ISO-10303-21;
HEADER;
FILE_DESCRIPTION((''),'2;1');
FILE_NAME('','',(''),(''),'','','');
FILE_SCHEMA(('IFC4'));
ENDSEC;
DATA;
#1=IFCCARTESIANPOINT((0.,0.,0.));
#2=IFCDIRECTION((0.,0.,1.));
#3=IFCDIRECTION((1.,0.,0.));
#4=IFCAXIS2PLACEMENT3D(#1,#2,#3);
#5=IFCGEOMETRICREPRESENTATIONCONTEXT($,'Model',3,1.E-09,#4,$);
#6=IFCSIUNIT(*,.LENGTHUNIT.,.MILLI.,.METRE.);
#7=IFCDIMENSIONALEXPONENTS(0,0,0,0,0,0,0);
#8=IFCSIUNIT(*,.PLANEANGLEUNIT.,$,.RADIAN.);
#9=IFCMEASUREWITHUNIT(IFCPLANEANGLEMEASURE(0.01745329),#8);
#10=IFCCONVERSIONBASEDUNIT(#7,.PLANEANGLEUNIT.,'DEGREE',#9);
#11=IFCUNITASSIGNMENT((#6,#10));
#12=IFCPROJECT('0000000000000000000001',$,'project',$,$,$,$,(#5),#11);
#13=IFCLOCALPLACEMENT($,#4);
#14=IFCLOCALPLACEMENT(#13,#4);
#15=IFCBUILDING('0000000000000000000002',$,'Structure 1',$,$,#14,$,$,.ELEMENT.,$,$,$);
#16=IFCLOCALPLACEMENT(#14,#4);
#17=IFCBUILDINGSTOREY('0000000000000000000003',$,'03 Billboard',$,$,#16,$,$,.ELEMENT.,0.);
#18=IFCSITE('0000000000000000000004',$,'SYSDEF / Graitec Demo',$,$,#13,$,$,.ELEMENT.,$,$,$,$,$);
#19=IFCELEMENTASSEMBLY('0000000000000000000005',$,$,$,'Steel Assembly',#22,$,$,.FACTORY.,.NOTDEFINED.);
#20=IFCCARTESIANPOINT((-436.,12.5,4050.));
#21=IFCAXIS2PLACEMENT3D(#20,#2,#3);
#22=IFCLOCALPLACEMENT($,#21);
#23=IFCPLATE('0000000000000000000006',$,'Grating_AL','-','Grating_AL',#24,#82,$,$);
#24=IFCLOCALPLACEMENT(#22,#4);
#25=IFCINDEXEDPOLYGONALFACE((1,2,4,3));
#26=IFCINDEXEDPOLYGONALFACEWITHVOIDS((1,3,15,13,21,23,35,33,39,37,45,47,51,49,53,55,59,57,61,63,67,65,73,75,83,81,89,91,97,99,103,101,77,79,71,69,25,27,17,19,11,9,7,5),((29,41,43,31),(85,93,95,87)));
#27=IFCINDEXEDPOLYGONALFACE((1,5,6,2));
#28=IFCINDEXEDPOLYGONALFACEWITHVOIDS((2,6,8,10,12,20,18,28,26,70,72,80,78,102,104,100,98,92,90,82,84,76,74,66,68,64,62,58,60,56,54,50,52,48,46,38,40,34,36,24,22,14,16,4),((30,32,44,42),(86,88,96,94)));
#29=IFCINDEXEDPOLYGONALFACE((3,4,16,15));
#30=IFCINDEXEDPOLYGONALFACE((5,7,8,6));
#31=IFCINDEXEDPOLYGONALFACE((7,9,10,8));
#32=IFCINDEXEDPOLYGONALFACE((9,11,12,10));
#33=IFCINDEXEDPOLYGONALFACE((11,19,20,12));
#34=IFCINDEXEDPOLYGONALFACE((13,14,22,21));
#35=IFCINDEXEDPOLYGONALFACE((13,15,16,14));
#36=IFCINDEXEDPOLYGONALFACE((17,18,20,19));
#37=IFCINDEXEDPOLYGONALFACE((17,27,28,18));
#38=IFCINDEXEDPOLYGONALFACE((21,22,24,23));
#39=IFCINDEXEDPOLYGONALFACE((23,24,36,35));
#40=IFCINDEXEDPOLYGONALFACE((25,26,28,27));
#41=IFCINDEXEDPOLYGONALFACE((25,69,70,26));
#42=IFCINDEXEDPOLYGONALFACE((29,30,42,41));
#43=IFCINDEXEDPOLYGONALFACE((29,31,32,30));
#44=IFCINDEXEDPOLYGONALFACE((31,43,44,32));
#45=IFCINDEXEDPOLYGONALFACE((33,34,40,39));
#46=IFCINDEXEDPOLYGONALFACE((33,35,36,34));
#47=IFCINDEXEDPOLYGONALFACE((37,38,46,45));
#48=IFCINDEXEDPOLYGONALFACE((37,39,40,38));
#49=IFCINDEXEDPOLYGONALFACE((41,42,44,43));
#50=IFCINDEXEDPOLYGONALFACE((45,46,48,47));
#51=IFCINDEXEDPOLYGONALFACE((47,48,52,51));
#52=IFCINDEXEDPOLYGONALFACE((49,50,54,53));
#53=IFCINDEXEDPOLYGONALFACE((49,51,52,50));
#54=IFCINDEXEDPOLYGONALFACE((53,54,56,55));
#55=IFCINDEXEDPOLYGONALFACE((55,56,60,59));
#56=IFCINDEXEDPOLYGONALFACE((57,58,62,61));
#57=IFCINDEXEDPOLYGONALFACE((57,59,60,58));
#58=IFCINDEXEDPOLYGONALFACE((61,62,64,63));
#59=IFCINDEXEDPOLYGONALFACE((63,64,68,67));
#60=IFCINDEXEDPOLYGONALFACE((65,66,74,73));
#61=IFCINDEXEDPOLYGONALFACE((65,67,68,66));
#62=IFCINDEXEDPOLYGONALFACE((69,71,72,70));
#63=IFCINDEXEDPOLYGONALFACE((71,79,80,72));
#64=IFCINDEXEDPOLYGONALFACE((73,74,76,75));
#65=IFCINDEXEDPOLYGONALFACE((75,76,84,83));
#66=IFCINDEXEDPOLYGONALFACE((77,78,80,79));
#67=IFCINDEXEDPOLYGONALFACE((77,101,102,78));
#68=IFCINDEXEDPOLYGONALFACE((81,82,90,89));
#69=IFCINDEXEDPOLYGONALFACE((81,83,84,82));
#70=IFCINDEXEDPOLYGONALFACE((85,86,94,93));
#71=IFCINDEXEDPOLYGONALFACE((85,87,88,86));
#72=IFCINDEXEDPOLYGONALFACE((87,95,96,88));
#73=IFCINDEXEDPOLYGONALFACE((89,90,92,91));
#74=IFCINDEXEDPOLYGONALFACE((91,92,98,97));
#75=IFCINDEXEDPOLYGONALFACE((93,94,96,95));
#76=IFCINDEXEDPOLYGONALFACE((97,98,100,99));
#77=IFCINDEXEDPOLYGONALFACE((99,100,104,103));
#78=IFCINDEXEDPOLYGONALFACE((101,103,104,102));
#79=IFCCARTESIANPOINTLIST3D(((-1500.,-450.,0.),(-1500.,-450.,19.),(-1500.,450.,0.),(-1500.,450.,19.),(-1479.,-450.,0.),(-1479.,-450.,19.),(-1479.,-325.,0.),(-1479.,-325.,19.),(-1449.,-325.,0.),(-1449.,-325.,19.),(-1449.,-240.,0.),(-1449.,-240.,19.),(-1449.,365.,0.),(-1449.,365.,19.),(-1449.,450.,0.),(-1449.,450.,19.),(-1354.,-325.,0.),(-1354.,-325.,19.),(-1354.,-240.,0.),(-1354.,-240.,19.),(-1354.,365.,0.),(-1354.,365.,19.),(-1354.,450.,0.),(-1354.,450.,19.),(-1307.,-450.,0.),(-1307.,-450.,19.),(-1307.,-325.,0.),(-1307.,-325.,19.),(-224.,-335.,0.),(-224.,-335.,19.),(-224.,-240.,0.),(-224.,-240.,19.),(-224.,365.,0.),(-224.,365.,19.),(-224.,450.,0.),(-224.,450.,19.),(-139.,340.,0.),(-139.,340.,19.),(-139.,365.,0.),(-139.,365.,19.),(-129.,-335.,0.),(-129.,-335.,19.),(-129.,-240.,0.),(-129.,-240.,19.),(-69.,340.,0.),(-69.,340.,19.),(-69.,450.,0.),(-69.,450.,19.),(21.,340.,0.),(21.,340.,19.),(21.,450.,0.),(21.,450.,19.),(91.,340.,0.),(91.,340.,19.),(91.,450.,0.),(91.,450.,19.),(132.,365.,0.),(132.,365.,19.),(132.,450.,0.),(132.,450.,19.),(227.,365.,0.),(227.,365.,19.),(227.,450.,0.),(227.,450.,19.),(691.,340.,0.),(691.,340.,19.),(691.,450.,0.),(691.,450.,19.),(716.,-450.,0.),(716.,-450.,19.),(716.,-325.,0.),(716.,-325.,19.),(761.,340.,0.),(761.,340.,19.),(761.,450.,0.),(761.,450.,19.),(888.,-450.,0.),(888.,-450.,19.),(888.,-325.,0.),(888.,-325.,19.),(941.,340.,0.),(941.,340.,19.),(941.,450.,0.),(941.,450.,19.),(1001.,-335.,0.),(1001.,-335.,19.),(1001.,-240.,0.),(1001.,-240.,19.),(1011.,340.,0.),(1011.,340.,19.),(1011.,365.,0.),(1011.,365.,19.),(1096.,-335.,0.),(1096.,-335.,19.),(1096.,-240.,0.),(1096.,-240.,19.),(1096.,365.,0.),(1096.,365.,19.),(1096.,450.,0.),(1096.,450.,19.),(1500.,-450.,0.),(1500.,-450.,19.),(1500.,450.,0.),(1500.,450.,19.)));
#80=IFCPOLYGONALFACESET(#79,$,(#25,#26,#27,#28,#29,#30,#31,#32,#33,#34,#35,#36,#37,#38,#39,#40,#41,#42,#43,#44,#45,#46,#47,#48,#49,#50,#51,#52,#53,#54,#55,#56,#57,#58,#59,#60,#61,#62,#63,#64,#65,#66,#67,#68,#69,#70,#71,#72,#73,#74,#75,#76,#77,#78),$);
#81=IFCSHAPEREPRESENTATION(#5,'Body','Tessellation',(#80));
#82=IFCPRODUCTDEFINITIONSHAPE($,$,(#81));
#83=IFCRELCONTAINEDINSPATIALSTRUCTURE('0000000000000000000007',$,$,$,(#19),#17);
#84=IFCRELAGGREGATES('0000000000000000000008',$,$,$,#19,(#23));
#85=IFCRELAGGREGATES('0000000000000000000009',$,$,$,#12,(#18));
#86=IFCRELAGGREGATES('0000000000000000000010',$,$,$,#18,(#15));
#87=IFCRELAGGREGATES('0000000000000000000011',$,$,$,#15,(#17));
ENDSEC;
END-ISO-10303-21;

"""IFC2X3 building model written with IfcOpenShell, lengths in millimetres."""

from ifc_helpers import new_model, entity, si_unit, converted_unit, frame, origin, origin_with_axes, place, context, project, spatial, polyline, outline, extrude, element, aggregate, save


model = new_model("IFC2X3")

# Units and contexts
model_context = context("Model", 3, precision=1e-09, world=origin_with_axes())
ifc_project = project(units=[si_unit("LENGTHUNIT", "METRE", prefix="MILLI"), converted_unit("PLANEANGLEUNIT", "DEGREE", entity("IfcPlaneAngleMeasure", 0.01745329), si_unit("PLANEANGLEUNIT", "RADIAN"), dimensions=[0, 0, 0, 0, 0, 0, 0])], contexts=[model_context])

# Site, building, storey
site_placement = place(None, origin_with_axes())
site = spatial("IfcSite", under=ifc_project, at=site_placement, Name="SYSDEF / Graitec Demo", CompositionType="ELEMENT")
building_placement = place(site_placement, origin_with_axes())
building = spatial("IfcBuilding", under=site, at=building_placement, Name="Structure 1", CompositionType="ELEMENT")
storey_placement = place(building_placement, origin_with_axes())
storey = spatial("IfcBuildingStorey", under=building, at=storey_placement, Name="03 Billboard", CompositionType="ELEMENT", Elevation=0.0)

# Element assembly, plate, openings
assembly_1_placement = place(None, frame((-436.0, 12.5, 4050.0), z_axis=(0.0, 0.0, 1.0), x_axis=(1.0, 0.0, 0.0)))
assembly_1 = element("IfcElementAssembly", 1, at=assembly_1_placement, inside=storey, ObjectType="Steel Assembly", AssemblyPlace="FACTORY", PredefinedType="NOTDEFINED")
plate_placement = place(assembly_1_placement, origin_with_axes())
plate = element("IfcPlate", 2, at=plate_placement, Name="Grating_AL", Description="-", ObjectType="Grating_AL", context=model_context, shape_type="SweptSolid", body=[
    extrude(outline(polyline([(-1500.0, -450.0), (1500.0, -450.0), (1500.0, 450.0), (-1500.0, 450.0), (-1500.0, -450.0)])), origin_with_axes(), (0.0, 0.0, 1.0), 19.0),
])
opening_1_placement = place(plate_placement, frame((0.0, 0.0, -0.1), z_axis=(0.0, 0.0, 1.0), x_axis=(1.0, 0.0, 0.0)))
element("IfcOpeningElement", 3, at=opening_1_placement, cuts=plate, ObjectType="Opening", context=model_context, shape_type="SweptSolid", body=[
    extrude(outline(polyline([(-1449.0, 365.0), (-1354.0, 365.0), (-1354.0, 460.0), (-1449.0, 460.0), (-1449.0, 365.0)])), origin(), (0.0, 0.0, 1.0), 19.2),
])
opening_2_placement = place(plate_placement, frame((0.0, 0.0, -0.1), z_axis=(0.0, 0.0, 1.0), x_axis=(1.0, 0.0, 0.0)))
element("IfcOpeningElement", 4, at=opening_2_placement, cuts=plate, ObjectType="Opening", context=model_context, shape_type="SweptSolid", body=[
    extrude(outline(polyline([(-224.0, 365.0), (-129.0, 365.0), (-129.0, 460.0), (-224.0, 460.0), (-224.0, 365.0)])), origin(), (0.0, 0.0, 1.0), 19.2),
])
opening_3_placement = place(plate_placement, frame((0.0, 0.0, -0.1), z_axis=(0.0, 0.0, 1.0), x_axis=(1.0, 0.0, 0.0)))
element("IfcOpeningElement", 5, at=opening_3_placement, cuts=plate, ObjectType="Opening", context=model_context, shape_type="SweptSolid", body=[
    extrude(outline(polyline([(-224.0, -335.0), (-129.0, -335.0), (-129.0, -240.0), (-224.0, -240.0), (-224.0, -335.0)])), origin(), (0.0, 0.0, 1.0), 19.2),
])
opening_4_placement = place(plate_placement, frame((0.0, 0.0, -0.1), z_axis=(0.0, 0.0, 1.0), x_axis=(1.0, 0.0, 0.0)))
element("IfcOpeningElement", 6, at=opening_4_placement, cuts=plate, ObjectType="Opening", context=model_context, shape_type="SweptSolid", body=[
    extrude(outline(polyline([(-1449.0, -335.0), (-1354.0, -335.0), (-1354.0, -240.0), (-1449.0, -240.0), (-1449.0, -335.0)])), origin(), (0.0, 0.0, 1.0), 19.2),
])
opening_5_placement = place(plate_placement, frame((0.0, 0.0, -0.1), z_axis=(0.0, 0.0, 1.0), x_axis=(1.0, 0.0, 0.0)))
element("IfcOpeningElement", 7, at=opening_5_placement, cuts=plate, ObjectType="Opening", context=model_context, shape_type="SweptSolid", body=[
    extrude(outline(polyline([(1001.0, 365.0), (1096.0, 365.0), (1096.0, 460.0), (1001.0, 460.0), (1001.0, 365.0)])), origin(), (0.0, 0.0, 1.0), 19.2),
])
opening_6_placement = place(plate_placement, frame((0.0, 0.0, -0.1), z_axis=(0.0, 0.0, 1.0), x_axis=(1.0, 0.0, 0.0)))
element("IfcOpeningElement", 8, at=opening_6_placement, cuts=plate, ObjectType="Opening", context=model_context, shape_type="SweptSolid", body=[
    extrude(outline(polyline([(1001.0, -335.0), (1096.0, -335.0), (1096.0, -240.0), (1001.0, -240.0), (1001.0, -335.0)])), origin(), (0.0, 0.0, 1.0), 19.2),
])
opening_7_placement = place(plate_placement, frame((0.0, 0.0, -0.1), z_axis=(0.0, 0.0, 1.0), x_axis=(1.0, 0.0, 0.0)))
element("IfcOpeningElement", 9, at=opening_7_placement, cuts=plate, ObjectType="Opening", context=model_context, shape_type="SweptSolid", body=[
    extrude(outline(polyline([(941.0, 340.0), (1011.0, 340.0), (1011.0, 460.0), (941.0, 460.0), (941.0, 340.0)])), origin(), (0.0, 0.0, 1.0), 19.2),
])
opening_8_placement = place(plate_placement, frame((0.0, 0.0, -0.1), z_axis=(0.0, 0.0, 1.0), x_axis=(1.0, 0.0, 0.0)))
element("IfcOpeningElement", 10, at=opening_8_placement, cuts=plate, ObjectType="Opening", context=model_context, shape_type="SweptSolid", body=[
    extrude(outline(polyline([(691.0, 340.0), (761.0, 340.0), (761.0, 460.0), (691.0, 460.0), (691.0, 340.0)])), origin(), (0.0, 0.0, 1.0), 19.2),
])
opening_9_placement = place(plate_placement, frame((56.0, 400.0, -0.1), z_axis=(0.0, 0.0, 1.0), x_axis=(1.0, 0.0, 0.0)))
element("IfcOpeningElement", 11, at=opening_9_placement, cuts=plate, ObjectType="Opening", context=model_context, shape_type="SweptSolid", body=[
    extrude(outline(polyline([(-35.0, -60.0), (35.0, -60.0), (35.0, 60.0), (-35.0, 60.0), (-35.0, -60.0)])), origin(), (0.0, 0.0, 1.0), 19.2),
])
opening_10_placement = place(plate_placement, frame((0.0, 0.0, -0.1), z_axis=(0.0, 0.0, 1.0), x_axis=(1.0, 0.0, 0.0)))
element("IfcOpeningElement", 12, at=opening_10_placement, cuts=plate, ObjectType="Opening", context=model_context, shape_type="SweptSolid", body=[
    extrude(outline(polyline([(-139.0, 340.0), (-69.0, 340.0), (-69.0, 460.0), (-139.0, 460.0), (-139.0, 340.0)])), origin(), (0.0, 0.0, 1.0), 19.2),
])
opening_11_placement = place(plate_placement, frame((0.0, 0.0, -0.1), z_axis=(0.0, 0.0, 1.0), x_axis=(1.0, 0.0, 0.0)))
element("IfcOpeningElement", 13, at=opening_11_placement, cuts=plate, ObjectType="Opening", context=model_context, shape_type="SweptSolid", body=[
    extrude(outline(polyline([(716.0, -485.0), (888.0, -485.0), (888.0, -325.0), (716.0, -325.0), (716.0, -485.0)])), origin(), (0.0, 0.0, 1.0), 19.2),
])
opening_12_placement = place(plate_placement, frame((0.0, 0.0, -0.1), z_axis=(0.0, 0.0, 1.0), x_axis=(1.0, 0.0, 0.0)))
element("IfcOpeningElement", 14, at=opening_12_placement, cuts=plate, ObjectType="Opening", context=model_context, shape_type="SweptSolid", body=[
    extrude(outline(polyline([(-1479.0, -485.0), (-1307.0, -485.0), (-1307.0, -325.0), (-1479.0, -325.0), (-1479.0, -485.0)])), origin(), (0.0, 0.0, 1.0), 19.2),
])
opening_13_placement = place(plate_placement, frame((0.0, 0.0, -0.1), z_axis=(0.0, 0.0, 1.0), x_axis=(1.0, 0.0, 0.0)))
element("IfcOpeningElement", 15, at=opening_13_placement, cuts=plate, ObjectType="Opening", context=model_context, shape_type="SweptSolid", body=[
    extrude(outline(polyline([(132.0, 365.0), (227.0, 365.0), (227.0, 460.0), (132.0, 460.0), (132.0, 365.0)])), origin(), (0.0, 0.0, 1.0), 19.2),
])
aggregate(assembly_1, [plate])

save(model, "model.ifc")
